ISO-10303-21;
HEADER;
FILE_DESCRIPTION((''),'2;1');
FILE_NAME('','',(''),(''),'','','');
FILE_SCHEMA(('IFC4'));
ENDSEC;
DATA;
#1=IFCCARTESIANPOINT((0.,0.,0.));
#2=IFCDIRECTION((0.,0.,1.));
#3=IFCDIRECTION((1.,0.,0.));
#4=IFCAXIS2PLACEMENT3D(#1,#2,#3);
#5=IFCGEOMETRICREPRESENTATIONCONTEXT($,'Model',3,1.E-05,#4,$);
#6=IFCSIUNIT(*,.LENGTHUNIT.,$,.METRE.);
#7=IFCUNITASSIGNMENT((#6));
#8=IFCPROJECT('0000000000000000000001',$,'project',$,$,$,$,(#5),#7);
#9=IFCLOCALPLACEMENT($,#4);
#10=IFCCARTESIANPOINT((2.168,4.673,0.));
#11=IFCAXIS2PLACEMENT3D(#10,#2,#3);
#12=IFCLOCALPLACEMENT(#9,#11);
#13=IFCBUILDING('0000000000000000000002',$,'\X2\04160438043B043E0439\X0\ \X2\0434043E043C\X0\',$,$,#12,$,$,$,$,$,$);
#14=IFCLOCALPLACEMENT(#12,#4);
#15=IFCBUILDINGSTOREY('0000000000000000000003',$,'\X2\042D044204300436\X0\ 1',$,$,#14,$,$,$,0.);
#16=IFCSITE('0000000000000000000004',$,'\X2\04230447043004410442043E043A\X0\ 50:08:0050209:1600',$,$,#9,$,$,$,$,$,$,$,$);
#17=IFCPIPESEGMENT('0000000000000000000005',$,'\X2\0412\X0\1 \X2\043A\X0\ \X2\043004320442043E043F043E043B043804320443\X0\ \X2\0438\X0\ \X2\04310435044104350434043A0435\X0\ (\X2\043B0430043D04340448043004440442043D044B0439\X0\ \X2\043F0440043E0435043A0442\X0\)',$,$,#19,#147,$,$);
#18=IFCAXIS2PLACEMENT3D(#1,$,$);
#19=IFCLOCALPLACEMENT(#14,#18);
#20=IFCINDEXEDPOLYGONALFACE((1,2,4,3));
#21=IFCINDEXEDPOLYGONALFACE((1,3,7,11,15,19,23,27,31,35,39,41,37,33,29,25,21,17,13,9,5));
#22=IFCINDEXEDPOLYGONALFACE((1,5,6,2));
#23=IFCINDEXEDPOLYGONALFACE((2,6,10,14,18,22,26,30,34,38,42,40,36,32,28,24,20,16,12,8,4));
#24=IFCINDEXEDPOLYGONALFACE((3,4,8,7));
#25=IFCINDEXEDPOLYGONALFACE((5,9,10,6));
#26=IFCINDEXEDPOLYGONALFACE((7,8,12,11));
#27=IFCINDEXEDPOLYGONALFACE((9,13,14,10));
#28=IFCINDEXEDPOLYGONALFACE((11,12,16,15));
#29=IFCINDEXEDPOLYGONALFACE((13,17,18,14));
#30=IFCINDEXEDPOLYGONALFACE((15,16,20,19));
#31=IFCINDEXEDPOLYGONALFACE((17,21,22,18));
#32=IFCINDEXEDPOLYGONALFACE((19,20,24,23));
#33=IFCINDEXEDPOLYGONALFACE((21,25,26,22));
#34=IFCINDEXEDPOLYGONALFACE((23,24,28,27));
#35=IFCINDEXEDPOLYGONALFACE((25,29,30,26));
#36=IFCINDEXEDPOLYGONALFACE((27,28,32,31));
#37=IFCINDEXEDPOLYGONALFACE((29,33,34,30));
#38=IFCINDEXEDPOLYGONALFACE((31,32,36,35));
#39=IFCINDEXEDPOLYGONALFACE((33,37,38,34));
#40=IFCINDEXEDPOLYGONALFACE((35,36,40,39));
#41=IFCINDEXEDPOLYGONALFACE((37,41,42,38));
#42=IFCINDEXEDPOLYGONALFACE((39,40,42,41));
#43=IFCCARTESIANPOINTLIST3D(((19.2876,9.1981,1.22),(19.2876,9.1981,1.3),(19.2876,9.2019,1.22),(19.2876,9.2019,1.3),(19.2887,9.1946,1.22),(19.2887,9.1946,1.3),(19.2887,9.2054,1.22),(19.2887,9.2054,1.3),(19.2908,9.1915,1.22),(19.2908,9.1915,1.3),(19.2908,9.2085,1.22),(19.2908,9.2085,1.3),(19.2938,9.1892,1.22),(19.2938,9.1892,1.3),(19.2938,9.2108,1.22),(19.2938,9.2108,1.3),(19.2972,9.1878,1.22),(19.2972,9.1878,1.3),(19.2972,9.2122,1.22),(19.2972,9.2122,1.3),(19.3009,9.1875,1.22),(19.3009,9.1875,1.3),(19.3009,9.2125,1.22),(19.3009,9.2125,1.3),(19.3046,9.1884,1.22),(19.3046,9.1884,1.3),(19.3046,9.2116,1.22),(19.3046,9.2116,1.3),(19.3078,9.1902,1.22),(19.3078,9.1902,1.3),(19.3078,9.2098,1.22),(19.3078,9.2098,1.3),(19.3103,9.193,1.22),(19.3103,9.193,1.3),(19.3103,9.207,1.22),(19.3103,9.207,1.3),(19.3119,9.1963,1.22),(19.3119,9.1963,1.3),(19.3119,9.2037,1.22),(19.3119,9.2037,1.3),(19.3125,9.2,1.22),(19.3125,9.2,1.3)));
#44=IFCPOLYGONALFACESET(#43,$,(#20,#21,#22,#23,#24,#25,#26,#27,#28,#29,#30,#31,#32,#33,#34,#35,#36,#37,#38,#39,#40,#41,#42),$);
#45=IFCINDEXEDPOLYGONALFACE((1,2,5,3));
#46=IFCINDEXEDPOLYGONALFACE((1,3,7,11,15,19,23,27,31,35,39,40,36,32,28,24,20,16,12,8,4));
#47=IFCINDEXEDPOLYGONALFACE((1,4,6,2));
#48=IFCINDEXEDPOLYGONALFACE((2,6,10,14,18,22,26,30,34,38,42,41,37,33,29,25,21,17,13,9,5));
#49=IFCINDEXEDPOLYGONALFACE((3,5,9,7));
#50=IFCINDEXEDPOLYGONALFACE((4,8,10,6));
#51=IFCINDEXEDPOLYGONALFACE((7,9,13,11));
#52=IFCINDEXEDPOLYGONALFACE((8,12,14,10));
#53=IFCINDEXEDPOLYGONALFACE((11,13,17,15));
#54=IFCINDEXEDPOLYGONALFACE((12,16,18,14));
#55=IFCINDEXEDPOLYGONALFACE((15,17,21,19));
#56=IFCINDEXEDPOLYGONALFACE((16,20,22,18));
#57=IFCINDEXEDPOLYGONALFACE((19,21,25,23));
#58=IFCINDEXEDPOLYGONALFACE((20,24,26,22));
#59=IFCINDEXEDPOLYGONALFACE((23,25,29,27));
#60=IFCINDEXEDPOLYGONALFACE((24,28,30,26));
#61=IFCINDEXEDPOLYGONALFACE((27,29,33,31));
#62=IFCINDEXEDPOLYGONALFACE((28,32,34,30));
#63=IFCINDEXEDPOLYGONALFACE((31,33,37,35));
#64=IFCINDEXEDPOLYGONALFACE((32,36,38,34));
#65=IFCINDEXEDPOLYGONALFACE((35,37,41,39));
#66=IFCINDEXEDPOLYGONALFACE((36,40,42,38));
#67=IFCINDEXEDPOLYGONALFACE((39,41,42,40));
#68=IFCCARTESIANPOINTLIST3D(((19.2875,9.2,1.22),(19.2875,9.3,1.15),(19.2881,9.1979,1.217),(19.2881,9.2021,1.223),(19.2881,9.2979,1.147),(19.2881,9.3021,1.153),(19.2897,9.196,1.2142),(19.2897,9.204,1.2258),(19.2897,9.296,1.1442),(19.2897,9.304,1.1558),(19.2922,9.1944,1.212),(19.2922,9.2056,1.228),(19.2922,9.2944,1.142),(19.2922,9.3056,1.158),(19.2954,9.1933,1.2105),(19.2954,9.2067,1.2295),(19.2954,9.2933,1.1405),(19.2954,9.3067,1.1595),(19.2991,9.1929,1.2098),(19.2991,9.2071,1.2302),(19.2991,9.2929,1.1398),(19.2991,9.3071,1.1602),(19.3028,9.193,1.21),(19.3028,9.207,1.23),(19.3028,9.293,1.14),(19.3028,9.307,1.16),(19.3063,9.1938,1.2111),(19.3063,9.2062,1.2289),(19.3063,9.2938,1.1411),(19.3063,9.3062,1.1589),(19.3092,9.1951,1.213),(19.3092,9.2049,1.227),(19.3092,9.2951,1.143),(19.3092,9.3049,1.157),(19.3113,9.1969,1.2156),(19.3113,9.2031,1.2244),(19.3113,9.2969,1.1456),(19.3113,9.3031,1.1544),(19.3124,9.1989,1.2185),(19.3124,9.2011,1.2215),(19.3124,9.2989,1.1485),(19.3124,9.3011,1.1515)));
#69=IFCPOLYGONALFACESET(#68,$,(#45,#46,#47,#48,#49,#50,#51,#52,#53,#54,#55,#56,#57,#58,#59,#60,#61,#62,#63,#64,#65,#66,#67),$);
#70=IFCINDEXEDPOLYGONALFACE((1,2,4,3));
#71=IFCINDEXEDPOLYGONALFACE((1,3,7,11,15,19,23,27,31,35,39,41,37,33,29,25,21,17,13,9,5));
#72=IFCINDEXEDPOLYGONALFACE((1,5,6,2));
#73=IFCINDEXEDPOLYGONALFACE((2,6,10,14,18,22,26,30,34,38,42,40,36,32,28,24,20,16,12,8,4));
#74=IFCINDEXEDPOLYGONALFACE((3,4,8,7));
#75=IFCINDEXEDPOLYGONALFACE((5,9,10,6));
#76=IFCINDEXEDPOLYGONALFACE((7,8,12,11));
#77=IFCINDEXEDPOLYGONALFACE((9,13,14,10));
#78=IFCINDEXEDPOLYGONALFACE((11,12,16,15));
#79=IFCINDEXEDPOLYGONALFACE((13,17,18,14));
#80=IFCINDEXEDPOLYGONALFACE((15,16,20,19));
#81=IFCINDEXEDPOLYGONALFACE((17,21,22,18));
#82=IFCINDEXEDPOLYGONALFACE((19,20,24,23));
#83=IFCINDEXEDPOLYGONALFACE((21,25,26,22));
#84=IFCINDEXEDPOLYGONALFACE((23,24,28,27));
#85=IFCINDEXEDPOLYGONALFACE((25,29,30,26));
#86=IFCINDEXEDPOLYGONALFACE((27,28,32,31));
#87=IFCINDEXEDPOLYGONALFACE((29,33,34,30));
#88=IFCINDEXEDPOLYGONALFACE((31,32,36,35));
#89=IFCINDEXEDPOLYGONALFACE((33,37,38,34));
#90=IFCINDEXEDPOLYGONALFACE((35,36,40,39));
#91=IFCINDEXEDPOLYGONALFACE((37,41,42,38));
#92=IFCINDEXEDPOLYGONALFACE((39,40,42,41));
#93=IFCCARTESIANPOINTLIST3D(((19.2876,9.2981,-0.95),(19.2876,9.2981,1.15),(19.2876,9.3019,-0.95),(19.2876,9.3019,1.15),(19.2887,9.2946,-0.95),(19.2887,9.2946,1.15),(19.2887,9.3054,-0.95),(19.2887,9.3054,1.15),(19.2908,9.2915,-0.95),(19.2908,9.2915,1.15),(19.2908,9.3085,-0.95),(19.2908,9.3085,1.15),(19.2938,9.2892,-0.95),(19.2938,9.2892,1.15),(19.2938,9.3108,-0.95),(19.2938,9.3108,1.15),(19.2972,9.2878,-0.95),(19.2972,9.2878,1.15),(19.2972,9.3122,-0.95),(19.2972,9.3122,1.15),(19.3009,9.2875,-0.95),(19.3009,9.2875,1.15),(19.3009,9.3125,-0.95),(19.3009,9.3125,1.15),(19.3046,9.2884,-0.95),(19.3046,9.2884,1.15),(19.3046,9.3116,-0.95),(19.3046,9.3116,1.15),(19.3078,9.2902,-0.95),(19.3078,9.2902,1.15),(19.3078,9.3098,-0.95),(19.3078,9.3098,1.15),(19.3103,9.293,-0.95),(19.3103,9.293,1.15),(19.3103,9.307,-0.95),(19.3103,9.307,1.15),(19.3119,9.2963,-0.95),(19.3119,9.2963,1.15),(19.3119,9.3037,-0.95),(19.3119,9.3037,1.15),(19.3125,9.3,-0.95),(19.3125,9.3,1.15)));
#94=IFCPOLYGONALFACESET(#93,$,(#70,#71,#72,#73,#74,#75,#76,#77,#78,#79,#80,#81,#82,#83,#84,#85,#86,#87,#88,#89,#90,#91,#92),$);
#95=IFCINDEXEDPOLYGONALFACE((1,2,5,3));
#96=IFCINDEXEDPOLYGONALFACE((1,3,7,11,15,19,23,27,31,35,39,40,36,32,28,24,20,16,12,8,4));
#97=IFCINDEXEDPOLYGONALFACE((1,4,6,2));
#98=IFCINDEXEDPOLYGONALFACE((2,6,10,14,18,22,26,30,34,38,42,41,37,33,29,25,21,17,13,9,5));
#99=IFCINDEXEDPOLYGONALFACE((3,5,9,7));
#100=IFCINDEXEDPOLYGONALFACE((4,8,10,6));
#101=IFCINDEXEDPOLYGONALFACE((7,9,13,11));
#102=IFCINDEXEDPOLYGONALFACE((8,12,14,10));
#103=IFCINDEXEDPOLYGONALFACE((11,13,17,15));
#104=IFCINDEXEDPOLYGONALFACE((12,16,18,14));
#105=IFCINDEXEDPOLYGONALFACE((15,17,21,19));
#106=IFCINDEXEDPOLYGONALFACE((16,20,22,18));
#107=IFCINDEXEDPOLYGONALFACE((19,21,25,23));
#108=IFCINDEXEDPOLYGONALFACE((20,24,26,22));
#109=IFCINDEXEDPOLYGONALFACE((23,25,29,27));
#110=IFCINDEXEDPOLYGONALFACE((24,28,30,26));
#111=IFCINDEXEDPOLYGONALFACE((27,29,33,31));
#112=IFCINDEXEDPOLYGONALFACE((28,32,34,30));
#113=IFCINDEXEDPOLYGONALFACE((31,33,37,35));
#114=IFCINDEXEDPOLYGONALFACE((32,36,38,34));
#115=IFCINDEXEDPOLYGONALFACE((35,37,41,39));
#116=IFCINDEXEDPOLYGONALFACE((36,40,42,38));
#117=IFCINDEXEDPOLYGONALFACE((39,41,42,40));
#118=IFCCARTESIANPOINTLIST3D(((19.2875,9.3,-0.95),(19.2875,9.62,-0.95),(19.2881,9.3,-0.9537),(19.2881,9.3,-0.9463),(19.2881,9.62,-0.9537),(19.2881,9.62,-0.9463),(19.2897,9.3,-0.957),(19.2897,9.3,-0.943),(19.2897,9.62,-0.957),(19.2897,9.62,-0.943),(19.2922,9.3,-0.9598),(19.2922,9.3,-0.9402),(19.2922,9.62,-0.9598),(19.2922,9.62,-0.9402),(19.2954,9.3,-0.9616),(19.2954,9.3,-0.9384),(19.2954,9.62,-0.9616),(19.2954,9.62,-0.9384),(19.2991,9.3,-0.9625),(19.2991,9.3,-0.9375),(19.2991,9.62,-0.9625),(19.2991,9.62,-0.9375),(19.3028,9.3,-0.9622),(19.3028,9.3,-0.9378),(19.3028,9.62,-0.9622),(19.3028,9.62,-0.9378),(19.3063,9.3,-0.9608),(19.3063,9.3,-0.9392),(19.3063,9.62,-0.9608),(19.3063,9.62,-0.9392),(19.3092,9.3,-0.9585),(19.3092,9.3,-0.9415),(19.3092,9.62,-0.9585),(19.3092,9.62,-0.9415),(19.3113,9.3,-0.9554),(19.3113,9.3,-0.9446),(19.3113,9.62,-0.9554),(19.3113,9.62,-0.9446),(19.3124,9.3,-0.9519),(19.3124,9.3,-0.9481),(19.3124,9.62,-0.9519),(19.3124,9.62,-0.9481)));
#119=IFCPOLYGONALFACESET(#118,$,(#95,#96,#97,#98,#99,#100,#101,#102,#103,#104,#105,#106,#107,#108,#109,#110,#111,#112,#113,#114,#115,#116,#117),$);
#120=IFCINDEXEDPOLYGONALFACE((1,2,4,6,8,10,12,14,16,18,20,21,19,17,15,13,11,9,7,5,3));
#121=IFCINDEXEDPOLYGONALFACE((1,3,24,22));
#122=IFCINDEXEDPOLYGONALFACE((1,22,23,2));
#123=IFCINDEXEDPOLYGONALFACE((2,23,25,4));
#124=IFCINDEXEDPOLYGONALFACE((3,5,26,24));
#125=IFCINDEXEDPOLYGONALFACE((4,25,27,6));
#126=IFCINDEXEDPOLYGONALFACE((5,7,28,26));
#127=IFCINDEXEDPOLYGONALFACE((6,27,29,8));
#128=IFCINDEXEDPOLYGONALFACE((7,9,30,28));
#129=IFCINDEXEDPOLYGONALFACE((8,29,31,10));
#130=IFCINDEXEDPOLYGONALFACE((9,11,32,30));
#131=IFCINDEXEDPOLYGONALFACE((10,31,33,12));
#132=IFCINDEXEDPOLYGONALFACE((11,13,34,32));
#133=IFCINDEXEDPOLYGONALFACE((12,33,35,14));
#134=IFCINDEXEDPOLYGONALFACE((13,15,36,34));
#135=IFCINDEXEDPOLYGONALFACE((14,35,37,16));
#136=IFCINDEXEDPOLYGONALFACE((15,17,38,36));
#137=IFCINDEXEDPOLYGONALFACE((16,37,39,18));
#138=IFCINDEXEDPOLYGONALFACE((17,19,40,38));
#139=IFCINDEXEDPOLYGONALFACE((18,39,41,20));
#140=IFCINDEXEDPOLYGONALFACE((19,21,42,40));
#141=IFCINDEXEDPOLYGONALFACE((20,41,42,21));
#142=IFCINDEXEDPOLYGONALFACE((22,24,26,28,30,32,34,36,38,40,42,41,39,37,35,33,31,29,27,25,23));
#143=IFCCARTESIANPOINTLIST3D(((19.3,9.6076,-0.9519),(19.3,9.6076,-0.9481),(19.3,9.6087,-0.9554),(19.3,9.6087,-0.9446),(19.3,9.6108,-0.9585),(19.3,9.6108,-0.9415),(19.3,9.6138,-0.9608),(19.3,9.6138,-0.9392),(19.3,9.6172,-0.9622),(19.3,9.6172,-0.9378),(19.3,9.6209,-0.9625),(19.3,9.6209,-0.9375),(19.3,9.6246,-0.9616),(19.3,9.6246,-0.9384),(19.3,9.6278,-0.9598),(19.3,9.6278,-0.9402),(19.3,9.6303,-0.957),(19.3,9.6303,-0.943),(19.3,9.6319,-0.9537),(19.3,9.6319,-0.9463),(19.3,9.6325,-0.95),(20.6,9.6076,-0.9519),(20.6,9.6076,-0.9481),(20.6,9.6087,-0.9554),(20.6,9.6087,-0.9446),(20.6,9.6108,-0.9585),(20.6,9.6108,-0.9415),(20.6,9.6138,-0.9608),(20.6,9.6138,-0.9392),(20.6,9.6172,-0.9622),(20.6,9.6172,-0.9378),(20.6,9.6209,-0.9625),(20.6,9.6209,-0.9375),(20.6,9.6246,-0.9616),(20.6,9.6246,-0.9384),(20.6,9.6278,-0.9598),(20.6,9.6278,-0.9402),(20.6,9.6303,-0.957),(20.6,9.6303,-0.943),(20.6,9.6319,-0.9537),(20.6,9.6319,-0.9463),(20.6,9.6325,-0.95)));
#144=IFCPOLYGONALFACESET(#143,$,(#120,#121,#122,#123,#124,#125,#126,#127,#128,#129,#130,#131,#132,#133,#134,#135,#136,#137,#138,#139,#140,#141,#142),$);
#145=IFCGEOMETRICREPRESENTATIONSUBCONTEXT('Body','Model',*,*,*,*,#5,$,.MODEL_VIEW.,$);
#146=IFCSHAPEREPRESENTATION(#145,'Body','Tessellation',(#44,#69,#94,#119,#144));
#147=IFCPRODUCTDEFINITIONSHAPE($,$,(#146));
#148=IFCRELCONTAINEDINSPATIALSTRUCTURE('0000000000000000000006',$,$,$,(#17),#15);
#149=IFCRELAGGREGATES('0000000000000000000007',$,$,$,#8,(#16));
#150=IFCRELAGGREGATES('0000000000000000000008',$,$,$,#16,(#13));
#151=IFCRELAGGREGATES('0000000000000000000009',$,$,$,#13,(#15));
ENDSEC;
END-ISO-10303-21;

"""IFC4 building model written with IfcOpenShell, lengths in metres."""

from ifc_helpers import new_model, si_unit, frame, origin_with_axes, origin_2d, place, context, subcontext, project, spatial, circle, extrude, element, save


model = new_model("IFC4")

# Units and contexts
model_context = context("Model", 3, precision=1e-05, world=origin_with_axes())
body_context = subcontext(model_context, "Body", "Model", "MODEL_VIEW")
ifc_project = project(units=[si_unit("LENGTHUNIT", "METRE")], contexts=[model_context])

# Site, building, storey
site_placement = place(None, origin_with_axes())
site = spatial("IfcSite", under=ifc_project, at=site_placement, Name="Участок 50:08:0050209:1600")
building_placement = place(site_placement, frame((2.168, 4.673, 0.0), z_axis=(0.0, 0.0, 1.0), x_axis=(1.0, 0.0, 0.0)))
building = spatial("IfcBuilding", under=site, at=building_placement, Name="Жилой дом")
storey_placement = place(building_placement, origin_with_axes())
storey = spatial("IfcBuildingStorey", under=building, at=storey_placement, Name="Этаж 1", Elevation=0.0)

# Pipe segment
pipe_segment_1_placement = place(storey_placement, origin_with_axes())
element("IfcPipeSegment", 1, at=pipe_segment_1_placement, inside=storey, Name="В1 к автополиву и беседке (ландшафтный проект)", context=body_context, shape_type="SweptSolid", body=[
    extrude(circle(Radius=0.0125, at=origin_2d()), frame((19.3, 9.2, 1.3), z_axis=(0.0, 0.0, -1.0), x_axis=(1.0, 0.0, 0.0)), (0.0, 0.0, 1.0), 0.08),
    extrude(circle(Radius=0.0125, at=origin_2d()), frame((19.3, 9.2, 1.22), z_axis=(0.0, 0.819232, -0.573462), x_axis=(-1.0, 0.0, 0.0)), (0.0, 0.0, 1.0), 0.1221),
    extrude(circle(Radius=0.0125, at=origin_2d()), frame((19.3, 9.3, 1.15), z_axis=(0.0, 0.0, -1.0), x_axis=(1.0, 0.0, 0.0)), (0.0, 0.0, 1.0), 2.1),
    extrude(circle(Radius=0.0125, at=origin_2d()), frame((19.3, 9.3, -0.95), z_axis=(0.0, 1.0, 0.0), x_axis=(-1.0, 0.0, 0.0)), (0.0, 0.0, 1.0), 0.32),
    extrude(circle(Radius=0.0125, at=origin_2d()), frame((19.3, 9.62, -0.95), z_axis=(1.0, 0.0, 0.0), x_axis=(0.0, 1.0, 0.0)), (0.0, 0.0, 1.0), 1.3),
])

save(model, "model.ifc")
